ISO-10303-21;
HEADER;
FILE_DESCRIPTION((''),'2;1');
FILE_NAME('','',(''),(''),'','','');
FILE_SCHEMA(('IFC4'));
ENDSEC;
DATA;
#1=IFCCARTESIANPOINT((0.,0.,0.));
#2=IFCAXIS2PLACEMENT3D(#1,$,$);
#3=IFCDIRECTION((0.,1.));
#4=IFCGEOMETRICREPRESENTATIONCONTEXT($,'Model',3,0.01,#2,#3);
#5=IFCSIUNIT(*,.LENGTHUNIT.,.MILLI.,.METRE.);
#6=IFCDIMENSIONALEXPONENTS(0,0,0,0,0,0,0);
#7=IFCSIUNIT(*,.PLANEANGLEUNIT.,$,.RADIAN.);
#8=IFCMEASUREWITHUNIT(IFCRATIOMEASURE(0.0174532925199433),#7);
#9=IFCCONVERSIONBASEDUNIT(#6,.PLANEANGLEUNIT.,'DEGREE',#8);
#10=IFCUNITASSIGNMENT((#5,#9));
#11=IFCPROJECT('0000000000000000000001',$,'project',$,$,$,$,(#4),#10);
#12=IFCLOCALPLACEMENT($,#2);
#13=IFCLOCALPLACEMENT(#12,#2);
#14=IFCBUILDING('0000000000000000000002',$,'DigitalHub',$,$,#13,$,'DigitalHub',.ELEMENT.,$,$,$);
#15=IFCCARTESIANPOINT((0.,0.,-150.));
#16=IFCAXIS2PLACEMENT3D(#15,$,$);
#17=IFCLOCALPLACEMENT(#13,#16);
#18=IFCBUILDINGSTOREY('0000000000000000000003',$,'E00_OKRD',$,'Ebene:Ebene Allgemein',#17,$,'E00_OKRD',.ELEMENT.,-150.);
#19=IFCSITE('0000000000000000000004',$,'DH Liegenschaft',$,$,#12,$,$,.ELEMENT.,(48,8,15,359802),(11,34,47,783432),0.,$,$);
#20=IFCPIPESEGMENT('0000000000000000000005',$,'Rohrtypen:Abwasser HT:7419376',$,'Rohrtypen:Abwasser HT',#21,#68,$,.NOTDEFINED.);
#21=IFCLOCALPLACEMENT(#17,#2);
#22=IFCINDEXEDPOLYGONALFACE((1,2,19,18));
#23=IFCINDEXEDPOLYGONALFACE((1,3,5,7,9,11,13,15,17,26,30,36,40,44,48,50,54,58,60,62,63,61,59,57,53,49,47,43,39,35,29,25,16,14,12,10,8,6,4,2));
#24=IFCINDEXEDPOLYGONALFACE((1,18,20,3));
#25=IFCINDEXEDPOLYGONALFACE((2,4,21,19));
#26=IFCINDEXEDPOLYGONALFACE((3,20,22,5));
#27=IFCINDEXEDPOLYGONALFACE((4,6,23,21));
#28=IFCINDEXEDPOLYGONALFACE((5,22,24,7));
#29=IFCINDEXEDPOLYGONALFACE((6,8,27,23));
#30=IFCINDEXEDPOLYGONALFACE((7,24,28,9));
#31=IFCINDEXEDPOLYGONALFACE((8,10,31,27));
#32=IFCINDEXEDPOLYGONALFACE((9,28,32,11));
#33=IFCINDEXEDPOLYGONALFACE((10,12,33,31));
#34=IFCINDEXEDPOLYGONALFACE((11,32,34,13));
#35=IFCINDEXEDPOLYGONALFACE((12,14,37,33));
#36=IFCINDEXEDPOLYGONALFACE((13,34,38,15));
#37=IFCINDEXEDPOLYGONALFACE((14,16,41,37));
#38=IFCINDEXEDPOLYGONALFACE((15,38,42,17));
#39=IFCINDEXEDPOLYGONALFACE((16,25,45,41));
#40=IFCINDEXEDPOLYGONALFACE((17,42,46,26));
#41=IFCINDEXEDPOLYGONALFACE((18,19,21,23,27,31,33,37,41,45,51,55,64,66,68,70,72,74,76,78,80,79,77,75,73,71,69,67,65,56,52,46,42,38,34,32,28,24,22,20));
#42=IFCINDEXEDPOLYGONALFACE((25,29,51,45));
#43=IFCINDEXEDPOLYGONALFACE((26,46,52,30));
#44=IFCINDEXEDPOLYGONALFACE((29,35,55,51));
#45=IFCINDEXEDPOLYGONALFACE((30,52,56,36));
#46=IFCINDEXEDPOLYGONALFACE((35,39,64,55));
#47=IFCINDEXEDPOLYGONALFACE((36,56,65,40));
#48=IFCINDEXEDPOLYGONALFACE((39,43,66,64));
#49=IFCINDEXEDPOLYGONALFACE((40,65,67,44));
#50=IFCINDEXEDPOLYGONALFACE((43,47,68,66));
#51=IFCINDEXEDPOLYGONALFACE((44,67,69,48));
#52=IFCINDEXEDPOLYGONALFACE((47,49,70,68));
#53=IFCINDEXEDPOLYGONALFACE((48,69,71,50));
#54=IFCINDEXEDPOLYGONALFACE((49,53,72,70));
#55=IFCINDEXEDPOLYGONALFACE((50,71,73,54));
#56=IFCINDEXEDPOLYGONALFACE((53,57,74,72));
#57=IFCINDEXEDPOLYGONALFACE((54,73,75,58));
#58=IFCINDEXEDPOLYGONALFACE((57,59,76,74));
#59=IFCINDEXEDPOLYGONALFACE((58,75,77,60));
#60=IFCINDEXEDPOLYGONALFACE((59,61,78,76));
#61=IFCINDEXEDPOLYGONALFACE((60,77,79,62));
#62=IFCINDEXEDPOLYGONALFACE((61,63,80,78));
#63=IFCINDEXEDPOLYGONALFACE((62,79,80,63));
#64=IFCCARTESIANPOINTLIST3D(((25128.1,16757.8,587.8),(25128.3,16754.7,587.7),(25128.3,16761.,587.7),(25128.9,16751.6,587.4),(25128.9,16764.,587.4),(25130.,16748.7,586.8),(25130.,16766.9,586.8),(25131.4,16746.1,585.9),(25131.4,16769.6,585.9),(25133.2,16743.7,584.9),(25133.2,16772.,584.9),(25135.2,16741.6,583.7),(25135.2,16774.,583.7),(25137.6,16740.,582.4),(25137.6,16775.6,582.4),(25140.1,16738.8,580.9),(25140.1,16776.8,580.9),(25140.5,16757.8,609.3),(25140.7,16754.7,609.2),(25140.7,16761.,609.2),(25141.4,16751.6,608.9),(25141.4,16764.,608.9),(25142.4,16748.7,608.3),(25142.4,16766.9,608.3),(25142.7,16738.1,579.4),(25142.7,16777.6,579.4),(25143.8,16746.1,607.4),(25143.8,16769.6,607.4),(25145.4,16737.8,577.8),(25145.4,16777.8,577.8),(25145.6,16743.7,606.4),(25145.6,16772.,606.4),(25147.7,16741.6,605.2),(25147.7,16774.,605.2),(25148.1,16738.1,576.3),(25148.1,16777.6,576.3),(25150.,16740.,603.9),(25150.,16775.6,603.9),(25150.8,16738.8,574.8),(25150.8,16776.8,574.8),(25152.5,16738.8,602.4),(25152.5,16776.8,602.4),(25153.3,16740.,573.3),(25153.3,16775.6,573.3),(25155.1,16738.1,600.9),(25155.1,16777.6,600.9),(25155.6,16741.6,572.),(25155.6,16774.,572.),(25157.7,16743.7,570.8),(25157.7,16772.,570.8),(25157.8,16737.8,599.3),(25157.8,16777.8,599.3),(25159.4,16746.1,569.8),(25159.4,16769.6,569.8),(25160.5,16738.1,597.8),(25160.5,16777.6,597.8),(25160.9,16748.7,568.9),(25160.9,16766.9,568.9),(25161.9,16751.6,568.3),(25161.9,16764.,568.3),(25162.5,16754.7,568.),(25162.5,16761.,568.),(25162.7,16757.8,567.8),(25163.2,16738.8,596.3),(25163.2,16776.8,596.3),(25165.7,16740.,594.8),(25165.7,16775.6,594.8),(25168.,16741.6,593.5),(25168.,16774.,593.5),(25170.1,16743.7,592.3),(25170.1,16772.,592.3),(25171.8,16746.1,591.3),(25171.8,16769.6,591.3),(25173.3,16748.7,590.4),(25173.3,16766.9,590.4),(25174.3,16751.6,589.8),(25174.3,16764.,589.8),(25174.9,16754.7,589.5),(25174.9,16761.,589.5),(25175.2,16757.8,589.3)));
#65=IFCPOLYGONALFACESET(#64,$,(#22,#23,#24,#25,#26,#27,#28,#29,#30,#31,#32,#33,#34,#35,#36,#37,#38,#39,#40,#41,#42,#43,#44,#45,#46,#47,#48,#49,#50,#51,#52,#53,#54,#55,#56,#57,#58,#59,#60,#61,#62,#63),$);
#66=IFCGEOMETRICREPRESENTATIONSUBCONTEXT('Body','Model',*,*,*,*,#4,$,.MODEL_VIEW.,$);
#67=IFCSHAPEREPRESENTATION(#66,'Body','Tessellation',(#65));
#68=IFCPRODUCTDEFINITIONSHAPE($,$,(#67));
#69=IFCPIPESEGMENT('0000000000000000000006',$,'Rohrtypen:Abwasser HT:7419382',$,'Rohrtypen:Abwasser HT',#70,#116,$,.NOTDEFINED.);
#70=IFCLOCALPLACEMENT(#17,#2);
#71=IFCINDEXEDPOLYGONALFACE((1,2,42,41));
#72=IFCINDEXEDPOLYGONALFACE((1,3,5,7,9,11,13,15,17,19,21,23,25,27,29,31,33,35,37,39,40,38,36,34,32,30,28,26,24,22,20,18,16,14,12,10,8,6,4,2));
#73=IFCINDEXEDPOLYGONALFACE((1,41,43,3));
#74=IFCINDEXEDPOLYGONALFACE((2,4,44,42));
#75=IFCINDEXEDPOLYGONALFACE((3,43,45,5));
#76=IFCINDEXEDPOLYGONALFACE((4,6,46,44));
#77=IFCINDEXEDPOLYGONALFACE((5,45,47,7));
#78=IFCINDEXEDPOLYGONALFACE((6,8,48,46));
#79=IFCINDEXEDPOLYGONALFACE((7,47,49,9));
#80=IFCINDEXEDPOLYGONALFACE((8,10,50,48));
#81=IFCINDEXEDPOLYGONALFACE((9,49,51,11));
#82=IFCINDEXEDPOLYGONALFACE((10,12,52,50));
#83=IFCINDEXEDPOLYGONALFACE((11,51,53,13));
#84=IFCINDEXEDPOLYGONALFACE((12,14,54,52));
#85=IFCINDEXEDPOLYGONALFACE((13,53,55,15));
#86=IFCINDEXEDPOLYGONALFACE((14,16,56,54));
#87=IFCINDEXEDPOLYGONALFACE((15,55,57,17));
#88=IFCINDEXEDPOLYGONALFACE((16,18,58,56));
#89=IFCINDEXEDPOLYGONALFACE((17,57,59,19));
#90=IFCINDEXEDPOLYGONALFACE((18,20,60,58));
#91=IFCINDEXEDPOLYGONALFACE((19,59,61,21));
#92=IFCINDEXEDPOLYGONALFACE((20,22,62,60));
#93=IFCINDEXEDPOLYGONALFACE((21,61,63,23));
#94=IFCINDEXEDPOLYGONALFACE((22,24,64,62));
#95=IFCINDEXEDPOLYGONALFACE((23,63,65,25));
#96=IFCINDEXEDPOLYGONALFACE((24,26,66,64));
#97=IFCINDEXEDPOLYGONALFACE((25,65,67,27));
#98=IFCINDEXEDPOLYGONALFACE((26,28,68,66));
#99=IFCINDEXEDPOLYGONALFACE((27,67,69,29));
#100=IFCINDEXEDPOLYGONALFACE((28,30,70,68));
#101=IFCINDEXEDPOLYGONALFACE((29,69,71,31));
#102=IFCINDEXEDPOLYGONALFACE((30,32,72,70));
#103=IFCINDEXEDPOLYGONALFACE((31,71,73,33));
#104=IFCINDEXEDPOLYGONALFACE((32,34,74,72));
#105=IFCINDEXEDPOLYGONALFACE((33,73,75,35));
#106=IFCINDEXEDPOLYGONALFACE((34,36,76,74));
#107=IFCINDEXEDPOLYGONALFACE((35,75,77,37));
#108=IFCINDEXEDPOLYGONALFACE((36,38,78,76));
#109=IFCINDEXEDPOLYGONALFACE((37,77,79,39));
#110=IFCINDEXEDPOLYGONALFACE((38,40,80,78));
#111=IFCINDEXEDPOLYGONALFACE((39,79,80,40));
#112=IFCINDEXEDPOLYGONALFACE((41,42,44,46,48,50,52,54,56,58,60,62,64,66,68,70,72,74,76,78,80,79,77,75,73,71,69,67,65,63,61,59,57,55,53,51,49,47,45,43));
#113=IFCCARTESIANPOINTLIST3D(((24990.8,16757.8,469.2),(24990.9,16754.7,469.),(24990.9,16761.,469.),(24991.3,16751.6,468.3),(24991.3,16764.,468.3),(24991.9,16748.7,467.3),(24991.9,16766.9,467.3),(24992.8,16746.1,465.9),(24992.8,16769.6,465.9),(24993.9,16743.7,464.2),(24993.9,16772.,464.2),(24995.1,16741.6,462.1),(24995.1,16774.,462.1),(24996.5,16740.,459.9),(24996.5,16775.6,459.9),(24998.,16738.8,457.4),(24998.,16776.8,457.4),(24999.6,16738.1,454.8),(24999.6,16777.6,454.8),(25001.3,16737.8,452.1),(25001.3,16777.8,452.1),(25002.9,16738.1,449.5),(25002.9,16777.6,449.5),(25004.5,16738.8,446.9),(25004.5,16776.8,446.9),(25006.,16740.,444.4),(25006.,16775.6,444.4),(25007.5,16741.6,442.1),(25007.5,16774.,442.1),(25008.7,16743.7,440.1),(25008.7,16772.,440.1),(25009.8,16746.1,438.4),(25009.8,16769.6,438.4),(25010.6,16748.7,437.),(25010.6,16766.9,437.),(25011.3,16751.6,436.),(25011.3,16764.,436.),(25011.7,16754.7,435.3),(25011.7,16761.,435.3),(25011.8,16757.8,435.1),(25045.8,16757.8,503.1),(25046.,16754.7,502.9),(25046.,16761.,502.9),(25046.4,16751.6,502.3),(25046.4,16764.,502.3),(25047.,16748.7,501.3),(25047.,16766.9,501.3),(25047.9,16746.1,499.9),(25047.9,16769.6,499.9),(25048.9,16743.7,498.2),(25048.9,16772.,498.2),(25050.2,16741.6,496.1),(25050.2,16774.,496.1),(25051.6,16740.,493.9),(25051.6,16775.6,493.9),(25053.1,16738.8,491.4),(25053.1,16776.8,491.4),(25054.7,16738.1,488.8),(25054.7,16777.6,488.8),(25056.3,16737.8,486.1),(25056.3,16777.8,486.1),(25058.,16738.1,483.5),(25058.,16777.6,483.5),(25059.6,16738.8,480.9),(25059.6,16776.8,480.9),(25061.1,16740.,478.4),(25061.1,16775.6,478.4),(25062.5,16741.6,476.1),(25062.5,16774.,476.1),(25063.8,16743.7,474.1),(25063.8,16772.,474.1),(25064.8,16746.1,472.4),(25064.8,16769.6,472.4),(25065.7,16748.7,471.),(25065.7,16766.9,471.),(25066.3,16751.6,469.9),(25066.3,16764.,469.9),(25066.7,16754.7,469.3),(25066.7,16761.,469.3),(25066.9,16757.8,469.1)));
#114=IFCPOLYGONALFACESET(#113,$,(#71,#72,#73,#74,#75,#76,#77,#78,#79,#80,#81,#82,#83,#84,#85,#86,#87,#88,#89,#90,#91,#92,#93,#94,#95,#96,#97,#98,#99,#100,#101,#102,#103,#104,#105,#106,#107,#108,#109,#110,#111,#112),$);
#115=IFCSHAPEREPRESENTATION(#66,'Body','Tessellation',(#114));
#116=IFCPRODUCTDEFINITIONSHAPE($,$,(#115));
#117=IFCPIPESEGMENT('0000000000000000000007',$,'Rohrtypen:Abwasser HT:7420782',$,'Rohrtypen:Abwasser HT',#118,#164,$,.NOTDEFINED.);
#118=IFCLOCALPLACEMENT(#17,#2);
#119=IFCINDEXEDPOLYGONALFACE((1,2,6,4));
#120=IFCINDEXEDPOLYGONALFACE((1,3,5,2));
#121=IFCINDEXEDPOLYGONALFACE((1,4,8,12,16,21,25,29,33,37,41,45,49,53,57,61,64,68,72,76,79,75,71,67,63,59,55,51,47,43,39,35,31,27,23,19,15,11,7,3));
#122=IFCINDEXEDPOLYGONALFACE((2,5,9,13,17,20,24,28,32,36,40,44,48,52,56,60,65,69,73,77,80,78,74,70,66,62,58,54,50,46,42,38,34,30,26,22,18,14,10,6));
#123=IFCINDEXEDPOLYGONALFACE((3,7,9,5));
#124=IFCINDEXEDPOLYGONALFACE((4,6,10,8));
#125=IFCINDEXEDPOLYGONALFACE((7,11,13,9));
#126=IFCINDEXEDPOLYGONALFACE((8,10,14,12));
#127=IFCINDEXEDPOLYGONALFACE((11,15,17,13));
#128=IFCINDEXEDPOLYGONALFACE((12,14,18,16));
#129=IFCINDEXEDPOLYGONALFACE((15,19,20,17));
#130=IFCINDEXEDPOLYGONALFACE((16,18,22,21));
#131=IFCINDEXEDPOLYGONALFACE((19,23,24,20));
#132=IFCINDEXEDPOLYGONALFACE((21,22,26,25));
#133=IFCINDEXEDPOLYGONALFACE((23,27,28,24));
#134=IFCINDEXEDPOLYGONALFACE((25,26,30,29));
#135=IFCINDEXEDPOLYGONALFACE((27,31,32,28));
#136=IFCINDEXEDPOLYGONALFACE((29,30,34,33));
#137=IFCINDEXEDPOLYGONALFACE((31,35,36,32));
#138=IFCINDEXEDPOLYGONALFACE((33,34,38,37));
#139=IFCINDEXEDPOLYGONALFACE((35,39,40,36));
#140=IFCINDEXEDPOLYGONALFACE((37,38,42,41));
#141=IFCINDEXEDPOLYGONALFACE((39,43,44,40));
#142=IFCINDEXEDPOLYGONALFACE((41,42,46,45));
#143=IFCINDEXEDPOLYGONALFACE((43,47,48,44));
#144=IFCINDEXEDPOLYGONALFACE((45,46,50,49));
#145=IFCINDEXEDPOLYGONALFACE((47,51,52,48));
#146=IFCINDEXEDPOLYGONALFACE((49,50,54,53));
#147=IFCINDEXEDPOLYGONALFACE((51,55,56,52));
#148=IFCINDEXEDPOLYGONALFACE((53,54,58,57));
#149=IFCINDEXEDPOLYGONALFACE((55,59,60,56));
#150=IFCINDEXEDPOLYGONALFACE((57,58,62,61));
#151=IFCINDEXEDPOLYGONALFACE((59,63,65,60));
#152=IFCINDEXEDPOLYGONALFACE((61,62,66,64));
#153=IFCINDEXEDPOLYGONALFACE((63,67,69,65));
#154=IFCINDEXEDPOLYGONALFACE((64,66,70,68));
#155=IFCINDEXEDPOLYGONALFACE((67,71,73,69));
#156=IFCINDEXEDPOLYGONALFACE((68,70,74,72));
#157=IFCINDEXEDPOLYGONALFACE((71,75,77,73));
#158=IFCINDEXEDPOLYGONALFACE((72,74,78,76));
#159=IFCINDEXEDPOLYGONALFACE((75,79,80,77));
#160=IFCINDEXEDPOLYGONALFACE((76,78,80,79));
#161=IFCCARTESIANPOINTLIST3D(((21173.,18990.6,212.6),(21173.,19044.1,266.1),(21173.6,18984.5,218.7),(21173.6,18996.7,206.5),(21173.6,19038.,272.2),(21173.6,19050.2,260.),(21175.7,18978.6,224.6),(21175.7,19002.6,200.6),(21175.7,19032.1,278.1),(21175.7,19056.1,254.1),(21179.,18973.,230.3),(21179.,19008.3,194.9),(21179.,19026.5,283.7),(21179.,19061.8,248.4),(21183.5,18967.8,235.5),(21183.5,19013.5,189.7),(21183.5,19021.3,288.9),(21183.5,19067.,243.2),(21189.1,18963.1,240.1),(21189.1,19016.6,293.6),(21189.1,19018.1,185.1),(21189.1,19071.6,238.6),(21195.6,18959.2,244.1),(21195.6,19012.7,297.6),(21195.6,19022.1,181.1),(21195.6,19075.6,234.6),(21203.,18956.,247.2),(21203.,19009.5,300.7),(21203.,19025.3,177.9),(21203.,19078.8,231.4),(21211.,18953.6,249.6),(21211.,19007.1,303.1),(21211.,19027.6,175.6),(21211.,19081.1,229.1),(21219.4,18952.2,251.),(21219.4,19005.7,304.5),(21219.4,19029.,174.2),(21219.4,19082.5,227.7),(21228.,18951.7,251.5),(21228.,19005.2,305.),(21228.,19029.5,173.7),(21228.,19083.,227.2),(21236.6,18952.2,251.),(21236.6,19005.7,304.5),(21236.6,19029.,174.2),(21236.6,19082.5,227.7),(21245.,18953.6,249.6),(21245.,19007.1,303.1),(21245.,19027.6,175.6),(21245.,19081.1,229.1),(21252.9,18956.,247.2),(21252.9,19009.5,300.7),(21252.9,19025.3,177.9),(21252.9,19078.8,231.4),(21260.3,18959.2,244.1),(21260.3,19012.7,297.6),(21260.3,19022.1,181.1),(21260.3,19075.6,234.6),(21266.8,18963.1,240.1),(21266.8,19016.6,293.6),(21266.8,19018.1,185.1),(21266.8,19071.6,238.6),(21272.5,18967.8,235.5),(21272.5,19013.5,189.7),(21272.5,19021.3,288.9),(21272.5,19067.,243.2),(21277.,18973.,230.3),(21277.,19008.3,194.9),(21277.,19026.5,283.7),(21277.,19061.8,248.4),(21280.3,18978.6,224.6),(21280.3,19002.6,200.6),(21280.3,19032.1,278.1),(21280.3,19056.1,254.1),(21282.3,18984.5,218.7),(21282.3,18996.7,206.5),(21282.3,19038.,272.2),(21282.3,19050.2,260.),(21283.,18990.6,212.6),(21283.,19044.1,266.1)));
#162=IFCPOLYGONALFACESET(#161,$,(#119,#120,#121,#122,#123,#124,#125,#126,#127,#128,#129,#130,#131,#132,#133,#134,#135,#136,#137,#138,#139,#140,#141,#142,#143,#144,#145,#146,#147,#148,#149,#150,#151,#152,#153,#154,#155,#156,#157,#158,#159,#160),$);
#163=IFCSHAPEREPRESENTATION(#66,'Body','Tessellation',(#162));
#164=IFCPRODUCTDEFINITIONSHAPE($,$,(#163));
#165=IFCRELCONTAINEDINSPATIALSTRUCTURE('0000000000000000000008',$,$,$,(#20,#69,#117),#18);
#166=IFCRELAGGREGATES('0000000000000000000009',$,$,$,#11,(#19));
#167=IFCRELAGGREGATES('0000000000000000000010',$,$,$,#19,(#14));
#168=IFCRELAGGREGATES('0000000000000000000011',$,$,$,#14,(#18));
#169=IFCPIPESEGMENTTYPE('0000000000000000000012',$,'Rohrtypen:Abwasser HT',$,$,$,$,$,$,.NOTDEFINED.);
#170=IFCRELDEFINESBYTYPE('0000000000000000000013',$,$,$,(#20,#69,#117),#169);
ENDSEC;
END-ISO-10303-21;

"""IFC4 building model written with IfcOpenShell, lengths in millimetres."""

from ifc_helpers import new_model, entity, si_unit, converted_unit, direction, frame, origin, place, context, subcontext, project, spatial, indexed_curve, outline, extrude, type_object, element, save


model = new_model("IFC4")

# Units and contexts
model_context = context("Model", 3, precision=0.01, world=origin(), true_north=direction((0.0, 1.0)))
body_context = subcontext(model_context, "Body", "Model", "MODEL_VIEW")
ifc_project = project(units=[si_unit("LENGTHUNIT", "METRE", prefix="MILLI"), converted_unit("PLANEANGLEUNIT", "DEGREE", entity("IfcRatioMeasure", 0.0174532925199433), si_unit("PLANEANGLEUNIT", "RADIAN"), dimensions=[0, 0, 0, 0, 0, 0, 0])], contexts=[model_context])

# Site, building, storey
site_placement = place(None, origin())
site = spatial("IfcSite", under=ifc_project, at=site_placement, Name="DH Liegenschaft", CompositionType="ELEMENT", RefLatitude=(48, 8, 15, 359802), RefLongitude=(11, 34, 47, 783432), RefElevation=0.0)
building_placement = place(site_placement, origin())
building = spatial("IfcBuilding", under=site, at=building_placement, Name="DigitalHub", LongName="DigitalHub", CompositionType="ELEMENT")
storey_placement = place(building_placement, frame((0.0, 0.0, -150.0)))
storey = spatial("IfcBuildingStorey", under=building, at=storey_placement, Name="E00_OKRD", ObjectType="Ebene:Ebene Allgemein", LongName="E00_OKRD", CompositionType="ELEMENT", Elevation=-150.0)

# Pipe segments
pipe_segment_type_1 = type_object("IfcPipeSegmentType", Name="Rohrtypen:Abwasser HT", PredefinedType="NOTDEFINED")
pipe_segment_1_placement = place(storey_placement, frame((25126.5, 16736.2, 566.2)))
element("IfcPipeSegment", 1, at=pipe_segment_1_placement, inside=storey, type_object=pipe_segment_type_1, Name="Rohrtypen:Abwasser HT:7419376", ObjectType="Rohrtypen:Abwasser HT", PredefinedType="NOTDEFINED", context=body_context, shape_type="SweptSolid", body=[
    extrude(outline(indexed_curve([(20.0, 0.0), (19.8, 3.1), (19.0, 6.2), (17.8, 9.1), (16.2, 11.8), (14.1, 14.1), (11.8, 16.2), (9.1, 17.8), (6.2, 19.0), (3.1, 19.8), (0.0, 20.0), (-3.1, 19.8), (-6.2, 19.0), (-9.1, 17.8), (-11.8, 16.2), (-14.1, 14.1), (-16.2, 11.8), (-17.8, 9.1), (-19.0, 6.2), (-19.8, 3.1), (-20.0, 0.0), (-19.8, -3.1), (-19.0, -6.2), (-17.8, -9.1), (-16.2, -11.8), (-14.1, -14.1), (-11.8, -16.2), (-9.1, -17.8), (-6.2, -19.0), (-3.1, -19.8), (0.0, -20.0), (3.1, -19.8), (6.2, -19.0), (9.1, -17.8), (11.8, -16.2), (14.1, -14.1), (16.2, -11.8), (17.8, -9.1), (19.0, -6.2), (19.8, -3.1), (20.0, 0.0)], self_intersect=False)), frame((18.9, 21.6, 11.6), z_axis=(0.5, 0.0, 0.866025), x_axis=(0.0, 1.0, 0.0)), (0.0, 0.0, 1.0), 24.8),
])
pipe_segment_2_placement = place(storey_placement, frame((24989.2, 16736.2, 433.5)))
element("IfcPipeSegment", 2, at=pipe_segment_2_placement, inside=storey, type_object=pipe_segment_type_1, Name="Rohrtypen:Abwasser HT:7419382", ObjectType="Rohrtypen:Abwasser HT", PredefinedType="NOTDEFINED", context=body_context, shape_type="SweptSolid", body=[
    extrude(outline(indexed_curve([(20.0, 0.0), (19.8, 3.1), (19.0, 6.2), (17.8, 9.1), (16.2, 11.8), (14.1, 14.1), (11.8, 16.2), (9.1, 17.8), (6.2, 19.0), (3.1, 19.8), (0.0, 20.0), (-3.1, 19.8), (-6.2, 19.0), (-9.1, 17.8), (-11.8, 16.2), (-14.1, 14.1), (-16.2, 11.8), (-17.8, 9.1), (-19.0, 6.2), (-19.8, 3.1), (-20.0, 0.0), (-19.8, -3.1), (-19.0, -6.2), (-17.8, -9.1), (-16.2, -11.8), (-14.1, -14.1), (-11.8, -16.2), (-9.1, -17.8), (-6.2, -19.0), (-3.1, -19.8), (0.0, -20.0), (3.1, -19.8), (6.2, -19.0), (9.1, -17.8), (11.8, -16.2), (14.1, -14.1), (16.2, -11.8), (17.8, -9.1), (19.0, -6.2), (19.8, -3.1), (20.0, 0.0)], self_intersect=False)), frame((12.1, 21.6, 18.6), z_axis=(0.851013, 0.0, 0.525145), x_axis=(0.0, 1.0, 0.0)), (0.0, 0.0, 1.0), 64.7),
])
pipe_segment_3_placement = place(storey_placement, frame((21171.4, 18950.1, 172.1)))
element("IfcPipeSegment", 3, at=pipe_segment_3_placement, inside=storey, type_object=pipe_segment_type_1, Name="Rohrtypen:Abwasser HT:7420782", ObjectType="Rohrtypen:Abwasser HT", PredefinedType="NOTDEFINED", context=body_context, shape_type="SweptSolid", body=[
    extrude(outline(indexed_curve([(55.0, 0.0), (54.3, 8.6), (52.3, 17.0), (49.0, 25.0), (44.5, 32.3), (38.9, 38.9), (32.3, 44.5), (25.0, 49.0), (17.0, 52.3), (8.6, 54.3), (0.0, 55.0), (-8.6, 54.3), (-17.0, 52.3), (-25.0, 49.0), (-32.3, 44.5), (-38.9, 38.9), (-44.5, 32.3), (-49.0, 25.0), (-52.3, 17.0), (-54.3, 8.6), (-55.0, 0.0), (-54.3, -8.6), (-52.3, -17.0), (-49.0, -25.0), (-44.5, -32.3), (-38.9, -38.9), (-32.3, -44.5), (-25.0, -49.0), (-17.0, -52.3), (-8.6, -54.3), (0.0, -55.0), (8.6, -54.3), (17.0, -52.3), (25.0, -49.0), (32.3, -44.5), (38.9, -38.9), (44.5, -32.3), (49.0, -25.0), (52.3, -17.0), (54.3, -8.6), (55.0, 0.0)], self_intersect=False)), frame((56.6, 40.5, 40.5), z_axis=(0.0, 0.707107, 0.707107), x_axis=(-1.0, 0.0, 0.0)), (0.0, 0.0, 1.0), 75.7),
])

save(model, "model.ifc")
